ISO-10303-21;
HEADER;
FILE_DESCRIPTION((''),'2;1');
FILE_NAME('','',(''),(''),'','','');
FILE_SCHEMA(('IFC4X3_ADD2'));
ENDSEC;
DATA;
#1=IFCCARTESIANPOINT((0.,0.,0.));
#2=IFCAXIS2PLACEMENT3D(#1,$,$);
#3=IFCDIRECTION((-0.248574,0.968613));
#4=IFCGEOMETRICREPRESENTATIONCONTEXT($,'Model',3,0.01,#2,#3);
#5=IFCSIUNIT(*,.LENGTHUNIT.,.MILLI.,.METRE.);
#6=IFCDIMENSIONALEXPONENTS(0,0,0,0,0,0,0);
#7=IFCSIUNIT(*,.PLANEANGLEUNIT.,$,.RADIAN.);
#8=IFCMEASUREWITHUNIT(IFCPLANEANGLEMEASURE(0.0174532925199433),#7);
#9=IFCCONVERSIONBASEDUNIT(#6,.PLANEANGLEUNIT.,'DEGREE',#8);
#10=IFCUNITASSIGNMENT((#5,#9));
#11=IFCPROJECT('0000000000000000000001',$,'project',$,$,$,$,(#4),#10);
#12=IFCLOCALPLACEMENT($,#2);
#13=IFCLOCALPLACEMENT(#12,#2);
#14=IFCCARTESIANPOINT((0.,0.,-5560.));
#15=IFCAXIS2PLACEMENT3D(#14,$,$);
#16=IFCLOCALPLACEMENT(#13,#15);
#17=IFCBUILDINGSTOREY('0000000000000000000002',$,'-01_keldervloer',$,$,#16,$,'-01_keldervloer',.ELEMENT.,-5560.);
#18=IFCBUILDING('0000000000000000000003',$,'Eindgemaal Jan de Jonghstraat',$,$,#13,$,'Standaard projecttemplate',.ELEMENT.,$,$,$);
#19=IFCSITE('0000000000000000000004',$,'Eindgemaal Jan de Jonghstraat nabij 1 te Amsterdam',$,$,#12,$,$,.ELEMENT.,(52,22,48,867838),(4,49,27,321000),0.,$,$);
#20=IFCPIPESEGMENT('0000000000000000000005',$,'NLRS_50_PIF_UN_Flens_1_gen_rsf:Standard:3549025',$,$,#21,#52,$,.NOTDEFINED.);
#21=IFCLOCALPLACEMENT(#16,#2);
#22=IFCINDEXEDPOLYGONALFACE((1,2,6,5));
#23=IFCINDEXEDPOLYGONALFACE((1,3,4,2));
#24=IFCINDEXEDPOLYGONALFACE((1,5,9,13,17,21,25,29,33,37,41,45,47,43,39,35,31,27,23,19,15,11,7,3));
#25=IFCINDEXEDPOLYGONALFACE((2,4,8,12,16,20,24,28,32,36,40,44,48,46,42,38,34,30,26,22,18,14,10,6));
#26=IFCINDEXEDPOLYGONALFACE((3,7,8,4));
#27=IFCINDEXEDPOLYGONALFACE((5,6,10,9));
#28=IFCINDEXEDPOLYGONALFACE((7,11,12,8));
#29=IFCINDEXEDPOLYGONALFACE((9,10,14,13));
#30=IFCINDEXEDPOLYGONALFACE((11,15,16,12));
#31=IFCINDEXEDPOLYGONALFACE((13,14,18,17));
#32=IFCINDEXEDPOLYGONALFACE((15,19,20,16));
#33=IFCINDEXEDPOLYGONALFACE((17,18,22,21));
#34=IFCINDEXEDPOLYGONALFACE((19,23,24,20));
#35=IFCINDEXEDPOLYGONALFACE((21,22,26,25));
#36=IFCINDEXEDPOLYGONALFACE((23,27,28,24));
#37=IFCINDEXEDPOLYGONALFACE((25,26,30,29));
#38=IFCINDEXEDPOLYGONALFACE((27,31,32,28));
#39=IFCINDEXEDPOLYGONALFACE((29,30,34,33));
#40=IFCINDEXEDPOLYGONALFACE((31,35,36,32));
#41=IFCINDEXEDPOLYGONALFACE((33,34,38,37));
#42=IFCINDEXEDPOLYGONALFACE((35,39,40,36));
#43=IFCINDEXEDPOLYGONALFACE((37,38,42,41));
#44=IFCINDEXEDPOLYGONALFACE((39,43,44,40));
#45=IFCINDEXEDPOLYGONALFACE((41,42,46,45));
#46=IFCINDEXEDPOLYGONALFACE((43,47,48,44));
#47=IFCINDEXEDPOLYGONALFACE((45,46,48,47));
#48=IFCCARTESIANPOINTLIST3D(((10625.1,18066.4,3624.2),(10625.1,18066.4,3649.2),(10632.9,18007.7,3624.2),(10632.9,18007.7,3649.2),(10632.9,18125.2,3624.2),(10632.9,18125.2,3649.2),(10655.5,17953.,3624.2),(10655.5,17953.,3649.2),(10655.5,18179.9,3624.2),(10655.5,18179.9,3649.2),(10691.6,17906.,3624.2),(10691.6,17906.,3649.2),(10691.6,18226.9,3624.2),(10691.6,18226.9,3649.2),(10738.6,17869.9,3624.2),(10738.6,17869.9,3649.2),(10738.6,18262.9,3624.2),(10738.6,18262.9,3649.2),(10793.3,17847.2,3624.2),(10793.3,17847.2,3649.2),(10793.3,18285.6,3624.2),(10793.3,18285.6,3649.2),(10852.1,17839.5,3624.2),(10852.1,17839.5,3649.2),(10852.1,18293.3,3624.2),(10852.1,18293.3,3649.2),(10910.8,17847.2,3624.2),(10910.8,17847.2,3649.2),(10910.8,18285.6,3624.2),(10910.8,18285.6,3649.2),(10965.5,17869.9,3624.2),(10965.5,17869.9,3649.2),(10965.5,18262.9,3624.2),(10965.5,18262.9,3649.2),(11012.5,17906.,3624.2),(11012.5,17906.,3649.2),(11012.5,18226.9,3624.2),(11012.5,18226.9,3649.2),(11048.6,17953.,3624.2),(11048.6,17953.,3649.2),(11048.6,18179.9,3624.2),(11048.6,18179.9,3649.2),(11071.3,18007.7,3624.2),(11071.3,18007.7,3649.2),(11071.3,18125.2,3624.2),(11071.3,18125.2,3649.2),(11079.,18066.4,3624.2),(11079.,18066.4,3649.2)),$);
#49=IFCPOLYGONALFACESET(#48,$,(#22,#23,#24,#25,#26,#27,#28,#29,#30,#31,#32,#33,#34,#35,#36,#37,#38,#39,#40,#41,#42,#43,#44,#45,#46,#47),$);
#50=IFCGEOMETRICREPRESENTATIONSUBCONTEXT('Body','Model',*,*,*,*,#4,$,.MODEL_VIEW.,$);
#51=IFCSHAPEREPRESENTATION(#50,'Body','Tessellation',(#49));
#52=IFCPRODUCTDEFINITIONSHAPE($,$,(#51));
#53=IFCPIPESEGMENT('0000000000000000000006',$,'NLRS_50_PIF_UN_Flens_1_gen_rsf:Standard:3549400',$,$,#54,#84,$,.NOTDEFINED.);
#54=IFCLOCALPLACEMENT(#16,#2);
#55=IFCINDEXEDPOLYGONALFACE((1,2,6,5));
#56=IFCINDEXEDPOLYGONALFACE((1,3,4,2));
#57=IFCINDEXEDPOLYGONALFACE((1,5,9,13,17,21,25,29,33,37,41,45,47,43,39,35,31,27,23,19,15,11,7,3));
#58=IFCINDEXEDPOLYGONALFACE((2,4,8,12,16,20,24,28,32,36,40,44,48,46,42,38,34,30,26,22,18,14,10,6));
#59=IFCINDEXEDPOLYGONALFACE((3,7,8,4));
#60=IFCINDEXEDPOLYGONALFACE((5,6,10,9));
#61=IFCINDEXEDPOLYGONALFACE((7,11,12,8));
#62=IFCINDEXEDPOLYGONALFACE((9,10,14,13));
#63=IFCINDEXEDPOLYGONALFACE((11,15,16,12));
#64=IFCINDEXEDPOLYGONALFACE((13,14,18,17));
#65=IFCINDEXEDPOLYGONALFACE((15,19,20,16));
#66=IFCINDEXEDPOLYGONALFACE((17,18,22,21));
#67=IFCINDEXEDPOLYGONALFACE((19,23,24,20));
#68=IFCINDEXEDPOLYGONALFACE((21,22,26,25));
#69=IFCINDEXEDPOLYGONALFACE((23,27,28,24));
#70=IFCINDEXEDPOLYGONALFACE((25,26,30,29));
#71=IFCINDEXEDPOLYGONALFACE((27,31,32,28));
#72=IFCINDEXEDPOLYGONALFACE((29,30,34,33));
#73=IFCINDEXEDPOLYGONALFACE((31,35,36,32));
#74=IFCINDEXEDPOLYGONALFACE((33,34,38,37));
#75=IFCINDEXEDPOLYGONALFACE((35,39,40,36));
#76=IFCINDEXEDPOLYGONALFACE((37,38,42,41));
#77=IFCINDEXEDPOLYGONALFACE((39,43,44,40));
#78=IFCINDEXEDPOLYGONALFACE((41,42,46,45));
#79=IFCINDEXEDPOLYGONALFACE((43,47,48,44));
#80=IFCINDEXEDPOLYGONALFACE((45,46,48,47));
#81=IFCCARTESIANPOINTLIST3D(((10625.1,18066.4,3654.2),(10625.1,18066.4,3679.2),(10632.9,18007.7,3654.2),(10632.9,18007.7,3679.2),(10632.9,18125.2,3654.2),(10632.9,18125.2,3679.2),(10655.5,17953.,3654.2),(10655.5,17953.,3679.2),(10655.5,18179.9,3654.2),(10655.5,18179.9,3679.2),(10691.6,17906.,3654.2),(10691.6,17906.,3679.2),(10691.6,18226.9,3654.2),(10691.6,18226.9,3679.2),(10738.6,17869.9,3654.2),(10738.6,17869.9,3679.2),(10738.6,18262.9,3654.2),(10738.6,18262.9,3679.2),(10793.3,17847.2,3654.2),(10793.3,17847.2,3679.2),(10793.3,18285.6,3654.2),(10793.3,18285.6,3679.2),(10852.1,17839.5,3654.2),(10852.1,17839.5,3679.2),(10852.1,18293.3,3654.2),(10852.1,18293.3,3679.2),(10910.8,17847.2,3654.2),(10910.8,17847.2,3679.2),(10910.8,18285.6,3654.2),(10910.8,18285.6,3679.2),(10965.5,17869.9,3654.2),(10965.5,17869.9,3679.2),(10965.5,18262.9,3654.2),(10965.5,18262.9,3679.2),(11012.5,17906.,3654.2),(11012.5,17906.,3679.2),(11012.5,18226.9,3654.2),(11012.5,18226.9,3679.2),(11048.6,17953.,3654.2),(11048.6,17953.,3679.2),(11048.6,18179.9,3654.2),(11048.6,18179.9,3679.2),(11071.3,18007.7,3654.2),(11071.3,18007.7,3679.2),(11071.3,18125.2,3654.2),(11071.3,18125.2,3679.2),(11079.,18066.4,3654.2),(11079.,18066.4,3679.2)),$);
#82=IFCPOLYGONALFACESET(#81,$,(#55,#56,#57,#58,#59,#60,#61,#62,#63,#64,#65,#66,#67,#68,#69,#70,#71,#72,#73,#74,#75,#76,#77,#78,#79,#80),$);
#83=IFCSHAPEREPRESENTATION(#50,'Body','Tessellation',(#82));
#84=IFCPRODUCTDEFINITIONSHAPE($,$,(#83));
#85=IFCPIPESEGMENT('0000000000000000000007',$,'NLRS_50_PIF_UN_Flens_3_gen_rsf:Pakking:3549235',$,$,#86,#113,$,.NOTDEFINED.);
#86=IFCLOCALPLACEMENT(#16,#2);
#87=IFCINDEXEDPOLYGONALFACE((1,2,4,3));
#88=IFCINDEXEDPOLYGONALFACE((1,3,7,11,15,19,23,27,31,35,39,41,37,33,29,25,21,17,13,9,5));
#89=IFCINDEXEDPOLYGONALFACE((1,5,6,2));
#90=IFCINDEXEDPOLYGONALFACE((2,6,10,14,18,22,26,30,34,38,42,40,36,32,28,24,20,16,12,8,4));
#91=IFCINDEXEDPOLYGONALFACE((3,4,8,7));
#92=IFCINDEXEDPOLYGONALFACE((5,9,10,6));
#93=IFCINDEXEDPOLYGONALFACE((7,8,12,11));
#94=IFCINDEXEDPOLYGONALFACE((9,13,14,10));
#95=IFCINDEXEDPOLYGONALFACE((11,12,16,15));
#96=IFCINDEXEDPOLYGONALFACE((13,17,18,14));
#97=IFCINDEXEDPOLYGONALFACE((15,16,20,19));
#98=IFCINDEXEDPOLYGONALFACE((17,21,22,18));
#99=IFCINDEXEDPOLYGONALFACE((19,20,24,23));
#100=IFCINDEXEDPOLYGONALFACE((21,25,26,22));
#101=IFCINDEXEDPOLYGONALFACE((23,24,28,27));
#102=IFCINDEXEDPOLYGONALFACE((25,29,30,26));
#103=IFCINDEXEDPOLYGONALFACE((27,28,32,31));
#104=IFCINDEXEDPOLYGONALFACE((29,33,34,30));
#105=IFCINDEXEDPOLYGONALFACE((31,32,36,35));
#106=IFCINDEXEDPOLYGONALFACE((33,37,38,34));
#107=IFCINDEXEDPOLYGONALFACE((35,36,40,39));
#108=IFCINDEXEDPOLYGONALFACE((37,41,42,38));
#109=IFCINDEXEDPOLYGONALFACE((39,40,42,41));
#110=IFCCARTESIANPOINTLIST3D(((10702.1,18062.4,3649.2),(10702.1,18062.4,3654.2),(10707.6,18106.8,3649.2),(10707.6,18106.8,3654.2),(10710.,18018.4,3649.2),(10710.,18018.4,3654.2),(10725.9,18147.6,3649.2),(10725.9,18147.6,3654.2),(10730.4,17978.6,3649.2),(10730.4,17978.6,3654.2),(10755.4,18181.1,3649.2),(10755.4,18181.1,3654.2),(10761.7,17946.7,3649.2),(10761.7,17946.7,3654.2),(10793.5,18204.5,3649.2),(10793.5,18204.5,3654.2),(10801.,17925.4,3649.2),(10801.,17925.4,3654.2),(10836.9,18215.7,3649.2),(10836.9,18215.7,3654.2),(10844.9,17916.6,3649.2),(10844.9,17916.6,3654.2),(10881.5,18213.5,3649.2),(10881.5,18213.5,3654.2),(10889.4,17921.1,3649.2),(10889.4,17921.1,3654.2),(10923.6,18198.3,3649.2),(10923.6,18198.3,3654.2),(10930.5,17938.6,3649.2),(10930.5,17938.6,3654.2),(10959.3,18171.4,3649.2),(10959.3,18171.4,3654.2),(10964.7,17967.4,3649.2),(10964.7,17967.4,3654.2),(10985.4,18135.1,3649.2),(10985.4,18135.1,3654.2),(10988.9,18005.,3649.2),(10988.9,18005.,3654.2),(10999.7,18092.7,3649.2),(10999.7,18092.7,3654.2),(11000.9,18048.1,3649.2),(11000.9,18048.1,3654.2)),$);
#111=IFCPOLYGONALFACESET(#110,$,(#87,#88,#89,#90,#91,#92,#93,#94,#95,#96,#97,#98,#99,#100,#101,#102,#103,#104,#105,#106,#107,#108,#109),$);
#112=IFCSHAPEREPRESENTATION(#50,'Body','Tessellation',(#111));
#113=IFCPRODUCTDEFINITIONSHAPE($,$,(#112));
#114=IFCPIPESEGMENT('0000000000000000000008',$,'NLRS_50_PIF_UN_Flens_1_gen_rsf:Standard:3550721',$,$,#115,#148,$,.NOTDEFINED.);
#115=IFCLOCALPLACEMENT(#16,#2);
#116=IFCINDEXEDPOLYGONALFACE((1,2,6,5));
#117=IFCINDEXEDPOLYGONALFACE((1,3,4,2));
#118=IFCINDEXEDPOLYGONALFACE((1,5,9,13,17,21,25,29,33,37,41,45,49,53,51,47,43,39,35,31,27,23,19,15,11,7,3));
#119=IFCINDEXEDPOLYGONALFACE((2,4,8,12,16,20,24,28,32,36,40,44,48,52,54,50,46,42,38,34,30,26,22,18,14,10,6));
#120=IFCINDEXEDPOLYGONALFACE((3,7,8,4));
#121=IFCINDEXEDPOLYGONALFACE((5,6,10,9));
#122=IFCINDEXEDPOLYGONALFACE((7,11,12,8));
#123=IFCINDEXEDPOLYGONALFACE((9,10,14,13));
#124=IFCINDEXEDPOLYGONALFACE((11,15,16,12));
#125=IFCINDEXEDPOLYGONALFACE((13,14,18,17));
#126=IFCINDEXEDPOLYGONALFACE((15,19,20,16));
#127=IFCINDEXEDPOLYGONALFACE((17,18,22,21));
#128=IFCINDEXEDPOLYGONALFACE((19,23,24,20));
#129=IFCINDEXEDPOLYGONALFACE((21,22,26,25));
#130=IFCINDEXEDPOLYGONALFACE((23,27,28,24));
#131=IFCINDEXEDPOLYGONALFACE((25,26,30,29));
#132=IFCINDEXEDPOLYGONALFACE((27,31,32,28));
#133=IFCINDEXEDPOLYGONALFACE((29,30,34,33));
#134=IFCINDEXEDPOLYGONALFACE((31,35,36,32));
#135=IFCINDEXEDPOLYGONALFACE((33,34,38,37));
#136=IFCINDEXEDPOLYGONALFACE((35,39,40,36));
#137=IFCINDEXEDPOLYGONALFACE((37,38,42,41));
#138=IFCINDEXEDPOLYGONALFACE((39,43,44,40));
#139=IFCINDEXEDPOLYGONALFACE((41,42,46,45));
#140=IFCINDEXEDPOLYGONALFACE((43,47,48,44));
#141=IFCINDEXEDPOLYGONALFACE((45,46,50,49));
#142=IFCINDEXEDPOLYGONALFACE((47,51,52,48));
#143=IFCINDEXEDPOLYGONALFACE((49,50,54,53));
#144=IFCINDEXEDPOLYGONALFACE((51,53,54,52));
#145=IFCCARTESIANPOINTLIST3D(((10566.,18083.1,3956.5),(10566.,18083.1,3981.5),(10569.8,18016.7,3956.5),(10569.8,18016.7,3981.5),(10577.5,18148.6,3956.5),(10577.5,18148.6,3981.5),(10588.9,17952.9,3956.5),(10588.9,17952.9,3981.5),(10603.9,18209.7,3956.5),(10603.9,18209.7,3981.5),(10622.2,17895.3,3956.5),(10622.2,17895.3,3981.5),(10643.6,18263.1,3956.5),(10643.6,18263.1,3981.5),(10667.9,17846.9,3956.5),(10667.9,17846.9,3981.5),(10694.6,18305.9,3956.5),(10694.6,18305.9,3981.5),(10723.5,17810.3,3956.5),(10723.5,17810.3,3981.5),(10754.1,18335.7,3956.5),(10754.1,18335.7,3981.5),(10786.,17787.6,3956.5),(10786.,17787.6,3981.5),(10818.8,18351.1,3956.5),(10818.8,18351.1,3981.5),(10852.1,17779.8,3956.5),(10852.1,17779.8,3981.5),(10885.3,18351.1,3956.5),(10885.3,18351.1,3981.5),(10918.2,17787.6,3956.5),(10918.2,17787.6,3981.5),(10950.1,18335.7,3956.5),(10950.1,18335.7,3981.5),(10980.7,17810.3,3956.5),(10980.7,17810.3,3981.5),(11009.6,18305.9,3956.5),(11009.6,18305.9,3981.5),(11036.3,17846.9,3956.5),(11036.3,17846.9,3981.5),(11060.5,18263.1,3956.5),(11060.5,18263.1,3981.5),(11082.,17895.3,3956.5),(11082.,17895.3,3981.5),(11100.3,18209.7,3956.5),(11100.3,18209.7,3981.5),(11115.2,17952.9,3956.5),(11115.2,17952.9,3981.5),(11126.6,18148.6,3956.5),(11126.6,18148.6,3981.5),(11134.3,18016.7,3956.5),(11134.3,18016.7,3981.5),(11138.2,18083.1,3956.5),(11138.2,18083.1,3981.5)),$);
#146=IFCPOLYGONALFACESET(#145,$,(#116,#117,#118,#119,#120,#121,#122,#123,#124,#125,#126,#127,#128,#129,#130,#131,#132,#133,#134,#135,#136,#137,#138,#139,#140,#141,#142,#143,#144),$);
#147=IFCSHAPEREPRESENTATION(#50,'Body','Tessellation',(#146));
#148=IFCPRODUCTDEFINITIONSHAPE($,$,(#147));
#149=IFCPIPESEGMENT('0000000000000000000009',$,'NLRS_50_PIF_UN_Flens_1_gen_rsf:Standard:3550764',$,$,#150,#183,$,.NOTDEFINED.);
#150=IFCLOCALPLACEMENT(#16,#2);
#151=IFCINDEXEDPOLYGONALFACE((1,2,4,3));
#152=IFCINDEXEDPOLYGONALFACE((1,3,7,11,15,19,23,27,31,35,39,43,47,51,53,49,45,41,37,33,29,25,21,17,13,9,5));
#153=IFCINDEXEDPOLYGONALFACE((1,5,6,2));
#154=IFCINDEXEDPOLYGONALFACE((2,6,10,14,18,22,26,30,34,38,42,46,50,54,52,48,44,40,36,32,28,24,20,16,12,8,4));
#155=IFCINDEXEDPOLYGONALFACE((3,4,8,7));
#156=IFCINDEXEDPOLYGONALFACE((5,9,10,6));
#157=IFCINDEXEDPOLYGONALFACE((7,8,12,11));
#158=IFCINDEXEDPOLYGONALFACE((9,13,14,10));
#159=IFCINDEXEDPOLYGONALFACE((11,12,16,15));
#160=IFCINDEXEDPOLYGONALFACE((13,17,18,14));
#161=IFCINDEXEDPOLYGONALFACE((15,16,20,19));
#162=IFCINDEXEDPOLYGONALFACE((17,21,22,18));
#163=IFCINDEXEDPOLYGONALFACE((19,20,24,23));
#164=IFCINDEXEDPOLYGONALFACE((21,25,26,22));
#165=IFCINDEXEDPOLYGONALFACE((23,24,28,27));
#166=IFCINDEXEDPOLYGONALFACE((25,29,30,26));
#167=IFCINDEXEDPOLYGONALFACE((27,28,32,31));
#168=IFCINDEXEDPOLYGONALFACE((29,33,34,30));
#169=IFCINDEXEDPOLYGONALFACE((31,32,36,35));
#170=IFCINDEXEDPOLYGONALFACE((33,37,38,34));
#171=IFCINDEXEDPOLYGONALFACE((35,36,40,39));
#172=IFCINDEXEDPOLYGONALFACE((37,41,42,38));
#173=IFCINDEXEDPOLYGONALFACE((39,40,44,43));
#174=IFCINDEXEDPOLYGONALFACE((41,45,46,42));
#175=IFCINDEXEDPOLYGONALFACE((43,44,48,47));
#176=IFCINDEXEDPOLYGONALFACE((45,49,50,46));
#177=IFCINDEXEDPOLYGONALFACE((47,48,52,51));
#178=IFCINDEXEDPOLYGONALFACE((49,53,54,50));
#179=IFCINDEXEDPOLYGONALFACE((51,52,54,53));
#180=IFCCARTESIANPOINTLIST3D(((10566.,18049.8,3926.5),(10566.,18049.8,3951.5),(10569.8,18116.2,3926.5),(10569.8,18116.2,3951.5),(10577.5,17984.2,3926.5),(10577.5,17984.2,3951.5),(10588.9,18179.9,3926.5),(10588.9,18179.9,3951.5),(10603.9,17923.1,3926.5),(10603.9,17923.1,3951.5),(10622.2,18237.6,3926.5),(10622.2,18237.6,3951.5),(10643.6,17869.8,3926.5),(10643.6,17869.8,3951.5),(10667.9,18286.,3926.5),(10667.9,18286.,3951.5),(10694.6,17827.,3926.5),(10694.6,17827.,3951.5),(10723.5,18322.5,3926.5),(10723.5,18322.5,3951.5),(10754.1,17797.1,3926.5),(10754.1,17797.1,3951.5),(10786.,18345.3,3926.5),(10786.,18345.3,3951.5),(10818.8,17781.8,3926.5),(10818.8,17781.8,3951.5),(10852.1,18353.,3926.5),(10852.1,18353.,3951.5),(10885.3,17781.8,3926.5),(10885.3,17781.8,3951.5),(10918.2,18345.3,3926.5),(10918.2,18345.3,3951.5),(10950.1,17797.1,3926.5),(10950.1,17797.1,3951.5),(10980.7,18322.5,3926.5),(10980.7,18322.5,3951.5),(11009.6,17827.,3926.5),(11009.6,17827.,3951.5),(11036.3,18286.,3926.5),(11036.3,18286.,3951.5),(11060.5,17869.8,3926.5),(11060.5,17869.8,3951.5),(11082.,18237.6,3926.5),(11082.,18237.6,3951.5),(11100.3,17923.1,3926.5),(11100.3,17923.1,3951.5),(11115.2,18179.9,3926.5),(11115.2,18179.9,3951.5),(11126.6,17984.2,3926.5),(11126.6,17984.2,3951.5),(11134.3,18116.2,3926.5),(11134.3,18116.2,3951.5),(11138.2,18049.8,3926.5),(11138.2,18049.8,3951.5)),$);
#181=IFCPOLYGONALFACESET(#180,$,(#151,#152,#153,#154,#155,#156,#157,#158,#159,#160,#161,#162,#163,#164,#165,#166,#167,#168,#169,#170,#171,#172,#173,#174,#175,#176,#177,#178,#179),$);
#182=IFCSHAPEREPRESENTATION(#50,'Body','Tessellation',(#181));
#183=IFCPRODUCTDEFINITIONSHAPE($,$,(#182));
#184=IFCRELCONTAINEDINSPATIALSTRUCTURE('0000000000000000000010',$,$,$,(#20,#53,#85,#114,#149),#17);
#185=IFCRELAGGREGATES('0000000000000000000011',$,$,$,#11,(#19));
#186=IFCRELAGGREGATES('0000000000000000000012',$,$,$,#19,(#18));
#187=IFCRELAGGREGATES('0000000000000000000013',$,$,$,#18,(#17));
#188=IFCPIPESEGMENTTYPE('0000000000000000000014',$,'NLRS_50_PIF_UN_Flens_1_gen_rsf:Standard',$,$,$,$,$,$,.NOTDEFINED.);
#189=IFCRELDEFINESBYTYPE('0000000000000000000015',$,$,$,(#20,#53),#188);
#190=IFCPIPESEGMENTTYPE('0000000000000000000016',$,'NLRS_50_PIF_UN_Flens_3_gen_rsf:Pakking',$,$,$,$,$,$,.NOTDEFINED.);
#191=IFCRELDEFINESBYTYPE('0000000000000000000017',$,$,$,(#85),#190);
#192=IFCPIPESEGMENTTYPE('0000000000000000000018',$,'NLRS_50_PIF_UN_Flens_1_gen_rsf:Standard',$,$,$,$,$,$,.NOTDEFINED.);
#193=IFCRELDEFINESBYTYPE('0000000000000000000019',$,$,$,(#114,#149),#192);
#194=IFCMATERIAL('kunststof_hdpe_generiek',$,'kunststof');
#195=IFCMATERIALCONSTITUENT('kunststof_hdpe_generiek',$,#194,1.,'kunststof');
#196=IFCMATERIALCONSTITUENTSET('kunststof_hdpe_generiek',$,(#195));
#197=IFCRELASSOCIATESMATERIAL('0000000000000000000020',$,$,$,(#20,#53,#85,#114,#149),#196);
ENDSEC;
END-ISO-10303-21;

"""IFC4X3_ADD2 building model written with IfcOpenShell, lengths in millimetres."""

from ifc_helpers import new_model, entity, si_unit, converted_unit, direction, frame, frame_2d, origin, place, context, subcontext, project, spatial, circle, extrude, source, transform, mapped, material, constituent, constituent_set, type_object, type_shapes, element, save


model = new_model("IFC4X3_ADD2")

# Units and contexts
model_context = context("Model", 3, precision=0.01, world=origin(), true_north=direction((-0.248574, 0.968613)))
body_context = subcontext(model_context, "Body", "Model", "MODEL_VIEW")
ifc_project = project(units=[si_unit("LENGTHUNIT", "METRE", prefix="MILLI"), converted_unit("PLANEANGLEUNIT", "DEGREE", entity("IfcPlaneAngleMeasure", 0.0174532925199433), si_unit("PLANEANGLEUNIT", "RADIAN"), dimensions=[0, 0, 0, 0, 0, 0, 0])], contexts=[model_context])

# Site, building, storey
site_placement = place(None, origin())
site = spatial("IfcSite", under=ifc_project, at=site_placement, Name="Eindgemaal Jan de Jonghstraat nabij 1 te Amsterdam", CompositionType="ELEMENT", RefLatitude=(52, 22, 48, 867838), RefLongitude=(4, 49, 27, 321000), RefElevation=0.0)
building_placement = place(site_placement, origin())
building = spatial("IfcBuilding", under=site, at=building_placement, Name="Eindgemaal Jan de Jonghstraat", LongName="Standaard projecttemplate", CompositionType="ELEMENT")
storey_placement = place(building_placement, frame((0.0, 0.0, -5560.0)))
storey = spatial("IfcBuildingStorey", under=building, at=storey_placement, Name="-01_keldervloer", LongName="-01_keldervloer", CompositionType="ELEMENT", Elevation=-5560.0)

# Pipe segments
ifc_material_1 = material(Name="kunststof_hdpe_generiek", Category="kunststof")
ifc_constituent_1 = constituent(ifc_material_1, Name="kunststof_hdpe_generiek", Category="kunststof", fraction=1.0)
ifc_constituent_set_1 = constituent_set(constituents=[ifc_constituent_1], Name="kunststof_hdpe_generiek")
pipe_segment_type_1 = type_object("IfcPipeSegmentType", Name="NLRS_50_PIF_UN_Flens_1_gen_rsf:Standard", PredefinedType="NOTDEFINED")
shared_shape_1 = source(origin(), body_context, "Body", "SweptSolid", [
    extrude(circle(Radius=226.9, at=frame_2d((0.0, 0.0), x_axis=(1.0, 0.0))), frame((-12.5, 0.0, 0.0), z_axis=(1.0, 0.0, 0.0), x_axis=(0.0, 1.0, 0.0)), (0.0, 0.0, 1.0), 25.0),
])
type_shapes(pipe_segment_type_1, [shared_shape_1])
for number, where, z_axis, x_axis, name in (
    (1, (10852.1, 18066.4, 3636.7), (0.0, 1.0, 0.0), (0.0, 0.0, -1.0), "NLRS_50_PIF_UN_Flens_1_gen_rsf:Standard:3549025"),
    (2, (10852.1, 18066.4, 3666.7), (0.0, 1.0, 0.0), (0.0, 0.0, 1.0), "NLRS_50_PIF_UN_Flens_1_gen_rsf:Standard:3549400"),
):
    element("IfcPipeSegment", number, at=place(storey_placement, frame(where, z_axis=z_axis, x_axis=x_axis)), inside=storey, type_object=pipe_segment_type_1, material=ifc_constituent_set_1, Name=name, PredefinedType="NOTDEFINED", context=body_context, shape_type="MappedRepresentation", body=[
        mapped(shared_shape_1, transform((0.0, 0.0, 0.0), scale=1.0)),
    ])
pipe_segment_type_2 = type_object("IfcPipeSegmentType", Name="NLRS_50_PIF_UN_Flens_3_gen_rsf:Pakking", PredefinedType="NOTDEFINED")
shared_shape_2 = source(origin(), body_context, "Body", "SweptSolid", [
    extrude(circle(Radius=150.0, at=frame_2d((0.0, 0.0), x_axis=(1.0, 0.0))), frame((0.0, 0.0, 0.0), z_axis=(0.0, 0.0, 1.0), x_axis=(0.0, -1.0, 0.0)), (0.0, 0.0, 1.0), 5.0),
])
type_shapes(pipe_segment_type_2, [shared_shape_2])
pipe_segment_1_placement = place(storey_placement, frame((10852.1, 18066.4, 3649.2), z_axis=(0.0, 0.0, 1.0), x_axis=(0.968613, 0.248574, 0.0)))
element("IfcPipeSegment", 3, at=pipe_segment_1_placement, inside=storey, type_object=pipe_segment_type_2, material=ifc_constituent_set_1, Name="NLRS_50_PIF_UN_Flens_3_gen_rsf:Pakking:3549235", PredefinedType="NOTDEFINED", context=body_context, shape_type="MappedRepresentation", body=[
    mapped(shared_shape_2, transform((0.0, 0.0, 0.0), scale=1.0)),
])
pipe_segment_type_3 = type_object("IfcPipeSegmentType", Name="NLRS_50_PIF_UN_Flens_1_gen_rsf:Standard", PredefinedType="NOTDEFINED")
shared_shape_3 = source(origin(), body_context, "Body", "SweptSolid", [
    extrude(circle(Radius=286.6, at=frame_2d((0.0, 0.0), x_axis=(1.0, 0.0))), frame((-12.5, 0.0, 0.0), z_axis=(1.0, 0.0, 0.0), x_axis=(0.0, 1.0, 0.0)), (0.0, 0.0, 1.0), 25.0),
])
type_shapes(pipe_segment_type_3, [shared_shape_3])
for number, where, z_axis, x_axis, name in (
    (4, (10852.1, 18066.4, 3969.0), (1.0, 0.0, 0.0), (0.0, 0.0, 1.0), "NLRS_50_PIF_UN_Flens_1_gen_rsf:Standard:3550721"),
    (5, (10852.1, 18066.4, 3939.0), (1.0, 0.0, 0.0), (0.0, 0.0, -1.0), "NLRS_50_PIF_UN_Flens_1_gen_rsf:Standard:3550764"),
):
    element("IfcPipeSegment", number, at=place(storey_placement, frame(where, z_axis=z_axis, x_axis=x_axis)), inside=storey, type_object=pipe_segment_type_3, material=ifc_constituent_set_1, Name=name, PredefinedType="NOTDEFINED", context=body_context, shape_type="MappedRepresentation", body=[
        mapped(shared_shape_3, transform((0.0, 0.0, 0.0), scale=1.0)),
    ])

save(model, "model.ifc")
